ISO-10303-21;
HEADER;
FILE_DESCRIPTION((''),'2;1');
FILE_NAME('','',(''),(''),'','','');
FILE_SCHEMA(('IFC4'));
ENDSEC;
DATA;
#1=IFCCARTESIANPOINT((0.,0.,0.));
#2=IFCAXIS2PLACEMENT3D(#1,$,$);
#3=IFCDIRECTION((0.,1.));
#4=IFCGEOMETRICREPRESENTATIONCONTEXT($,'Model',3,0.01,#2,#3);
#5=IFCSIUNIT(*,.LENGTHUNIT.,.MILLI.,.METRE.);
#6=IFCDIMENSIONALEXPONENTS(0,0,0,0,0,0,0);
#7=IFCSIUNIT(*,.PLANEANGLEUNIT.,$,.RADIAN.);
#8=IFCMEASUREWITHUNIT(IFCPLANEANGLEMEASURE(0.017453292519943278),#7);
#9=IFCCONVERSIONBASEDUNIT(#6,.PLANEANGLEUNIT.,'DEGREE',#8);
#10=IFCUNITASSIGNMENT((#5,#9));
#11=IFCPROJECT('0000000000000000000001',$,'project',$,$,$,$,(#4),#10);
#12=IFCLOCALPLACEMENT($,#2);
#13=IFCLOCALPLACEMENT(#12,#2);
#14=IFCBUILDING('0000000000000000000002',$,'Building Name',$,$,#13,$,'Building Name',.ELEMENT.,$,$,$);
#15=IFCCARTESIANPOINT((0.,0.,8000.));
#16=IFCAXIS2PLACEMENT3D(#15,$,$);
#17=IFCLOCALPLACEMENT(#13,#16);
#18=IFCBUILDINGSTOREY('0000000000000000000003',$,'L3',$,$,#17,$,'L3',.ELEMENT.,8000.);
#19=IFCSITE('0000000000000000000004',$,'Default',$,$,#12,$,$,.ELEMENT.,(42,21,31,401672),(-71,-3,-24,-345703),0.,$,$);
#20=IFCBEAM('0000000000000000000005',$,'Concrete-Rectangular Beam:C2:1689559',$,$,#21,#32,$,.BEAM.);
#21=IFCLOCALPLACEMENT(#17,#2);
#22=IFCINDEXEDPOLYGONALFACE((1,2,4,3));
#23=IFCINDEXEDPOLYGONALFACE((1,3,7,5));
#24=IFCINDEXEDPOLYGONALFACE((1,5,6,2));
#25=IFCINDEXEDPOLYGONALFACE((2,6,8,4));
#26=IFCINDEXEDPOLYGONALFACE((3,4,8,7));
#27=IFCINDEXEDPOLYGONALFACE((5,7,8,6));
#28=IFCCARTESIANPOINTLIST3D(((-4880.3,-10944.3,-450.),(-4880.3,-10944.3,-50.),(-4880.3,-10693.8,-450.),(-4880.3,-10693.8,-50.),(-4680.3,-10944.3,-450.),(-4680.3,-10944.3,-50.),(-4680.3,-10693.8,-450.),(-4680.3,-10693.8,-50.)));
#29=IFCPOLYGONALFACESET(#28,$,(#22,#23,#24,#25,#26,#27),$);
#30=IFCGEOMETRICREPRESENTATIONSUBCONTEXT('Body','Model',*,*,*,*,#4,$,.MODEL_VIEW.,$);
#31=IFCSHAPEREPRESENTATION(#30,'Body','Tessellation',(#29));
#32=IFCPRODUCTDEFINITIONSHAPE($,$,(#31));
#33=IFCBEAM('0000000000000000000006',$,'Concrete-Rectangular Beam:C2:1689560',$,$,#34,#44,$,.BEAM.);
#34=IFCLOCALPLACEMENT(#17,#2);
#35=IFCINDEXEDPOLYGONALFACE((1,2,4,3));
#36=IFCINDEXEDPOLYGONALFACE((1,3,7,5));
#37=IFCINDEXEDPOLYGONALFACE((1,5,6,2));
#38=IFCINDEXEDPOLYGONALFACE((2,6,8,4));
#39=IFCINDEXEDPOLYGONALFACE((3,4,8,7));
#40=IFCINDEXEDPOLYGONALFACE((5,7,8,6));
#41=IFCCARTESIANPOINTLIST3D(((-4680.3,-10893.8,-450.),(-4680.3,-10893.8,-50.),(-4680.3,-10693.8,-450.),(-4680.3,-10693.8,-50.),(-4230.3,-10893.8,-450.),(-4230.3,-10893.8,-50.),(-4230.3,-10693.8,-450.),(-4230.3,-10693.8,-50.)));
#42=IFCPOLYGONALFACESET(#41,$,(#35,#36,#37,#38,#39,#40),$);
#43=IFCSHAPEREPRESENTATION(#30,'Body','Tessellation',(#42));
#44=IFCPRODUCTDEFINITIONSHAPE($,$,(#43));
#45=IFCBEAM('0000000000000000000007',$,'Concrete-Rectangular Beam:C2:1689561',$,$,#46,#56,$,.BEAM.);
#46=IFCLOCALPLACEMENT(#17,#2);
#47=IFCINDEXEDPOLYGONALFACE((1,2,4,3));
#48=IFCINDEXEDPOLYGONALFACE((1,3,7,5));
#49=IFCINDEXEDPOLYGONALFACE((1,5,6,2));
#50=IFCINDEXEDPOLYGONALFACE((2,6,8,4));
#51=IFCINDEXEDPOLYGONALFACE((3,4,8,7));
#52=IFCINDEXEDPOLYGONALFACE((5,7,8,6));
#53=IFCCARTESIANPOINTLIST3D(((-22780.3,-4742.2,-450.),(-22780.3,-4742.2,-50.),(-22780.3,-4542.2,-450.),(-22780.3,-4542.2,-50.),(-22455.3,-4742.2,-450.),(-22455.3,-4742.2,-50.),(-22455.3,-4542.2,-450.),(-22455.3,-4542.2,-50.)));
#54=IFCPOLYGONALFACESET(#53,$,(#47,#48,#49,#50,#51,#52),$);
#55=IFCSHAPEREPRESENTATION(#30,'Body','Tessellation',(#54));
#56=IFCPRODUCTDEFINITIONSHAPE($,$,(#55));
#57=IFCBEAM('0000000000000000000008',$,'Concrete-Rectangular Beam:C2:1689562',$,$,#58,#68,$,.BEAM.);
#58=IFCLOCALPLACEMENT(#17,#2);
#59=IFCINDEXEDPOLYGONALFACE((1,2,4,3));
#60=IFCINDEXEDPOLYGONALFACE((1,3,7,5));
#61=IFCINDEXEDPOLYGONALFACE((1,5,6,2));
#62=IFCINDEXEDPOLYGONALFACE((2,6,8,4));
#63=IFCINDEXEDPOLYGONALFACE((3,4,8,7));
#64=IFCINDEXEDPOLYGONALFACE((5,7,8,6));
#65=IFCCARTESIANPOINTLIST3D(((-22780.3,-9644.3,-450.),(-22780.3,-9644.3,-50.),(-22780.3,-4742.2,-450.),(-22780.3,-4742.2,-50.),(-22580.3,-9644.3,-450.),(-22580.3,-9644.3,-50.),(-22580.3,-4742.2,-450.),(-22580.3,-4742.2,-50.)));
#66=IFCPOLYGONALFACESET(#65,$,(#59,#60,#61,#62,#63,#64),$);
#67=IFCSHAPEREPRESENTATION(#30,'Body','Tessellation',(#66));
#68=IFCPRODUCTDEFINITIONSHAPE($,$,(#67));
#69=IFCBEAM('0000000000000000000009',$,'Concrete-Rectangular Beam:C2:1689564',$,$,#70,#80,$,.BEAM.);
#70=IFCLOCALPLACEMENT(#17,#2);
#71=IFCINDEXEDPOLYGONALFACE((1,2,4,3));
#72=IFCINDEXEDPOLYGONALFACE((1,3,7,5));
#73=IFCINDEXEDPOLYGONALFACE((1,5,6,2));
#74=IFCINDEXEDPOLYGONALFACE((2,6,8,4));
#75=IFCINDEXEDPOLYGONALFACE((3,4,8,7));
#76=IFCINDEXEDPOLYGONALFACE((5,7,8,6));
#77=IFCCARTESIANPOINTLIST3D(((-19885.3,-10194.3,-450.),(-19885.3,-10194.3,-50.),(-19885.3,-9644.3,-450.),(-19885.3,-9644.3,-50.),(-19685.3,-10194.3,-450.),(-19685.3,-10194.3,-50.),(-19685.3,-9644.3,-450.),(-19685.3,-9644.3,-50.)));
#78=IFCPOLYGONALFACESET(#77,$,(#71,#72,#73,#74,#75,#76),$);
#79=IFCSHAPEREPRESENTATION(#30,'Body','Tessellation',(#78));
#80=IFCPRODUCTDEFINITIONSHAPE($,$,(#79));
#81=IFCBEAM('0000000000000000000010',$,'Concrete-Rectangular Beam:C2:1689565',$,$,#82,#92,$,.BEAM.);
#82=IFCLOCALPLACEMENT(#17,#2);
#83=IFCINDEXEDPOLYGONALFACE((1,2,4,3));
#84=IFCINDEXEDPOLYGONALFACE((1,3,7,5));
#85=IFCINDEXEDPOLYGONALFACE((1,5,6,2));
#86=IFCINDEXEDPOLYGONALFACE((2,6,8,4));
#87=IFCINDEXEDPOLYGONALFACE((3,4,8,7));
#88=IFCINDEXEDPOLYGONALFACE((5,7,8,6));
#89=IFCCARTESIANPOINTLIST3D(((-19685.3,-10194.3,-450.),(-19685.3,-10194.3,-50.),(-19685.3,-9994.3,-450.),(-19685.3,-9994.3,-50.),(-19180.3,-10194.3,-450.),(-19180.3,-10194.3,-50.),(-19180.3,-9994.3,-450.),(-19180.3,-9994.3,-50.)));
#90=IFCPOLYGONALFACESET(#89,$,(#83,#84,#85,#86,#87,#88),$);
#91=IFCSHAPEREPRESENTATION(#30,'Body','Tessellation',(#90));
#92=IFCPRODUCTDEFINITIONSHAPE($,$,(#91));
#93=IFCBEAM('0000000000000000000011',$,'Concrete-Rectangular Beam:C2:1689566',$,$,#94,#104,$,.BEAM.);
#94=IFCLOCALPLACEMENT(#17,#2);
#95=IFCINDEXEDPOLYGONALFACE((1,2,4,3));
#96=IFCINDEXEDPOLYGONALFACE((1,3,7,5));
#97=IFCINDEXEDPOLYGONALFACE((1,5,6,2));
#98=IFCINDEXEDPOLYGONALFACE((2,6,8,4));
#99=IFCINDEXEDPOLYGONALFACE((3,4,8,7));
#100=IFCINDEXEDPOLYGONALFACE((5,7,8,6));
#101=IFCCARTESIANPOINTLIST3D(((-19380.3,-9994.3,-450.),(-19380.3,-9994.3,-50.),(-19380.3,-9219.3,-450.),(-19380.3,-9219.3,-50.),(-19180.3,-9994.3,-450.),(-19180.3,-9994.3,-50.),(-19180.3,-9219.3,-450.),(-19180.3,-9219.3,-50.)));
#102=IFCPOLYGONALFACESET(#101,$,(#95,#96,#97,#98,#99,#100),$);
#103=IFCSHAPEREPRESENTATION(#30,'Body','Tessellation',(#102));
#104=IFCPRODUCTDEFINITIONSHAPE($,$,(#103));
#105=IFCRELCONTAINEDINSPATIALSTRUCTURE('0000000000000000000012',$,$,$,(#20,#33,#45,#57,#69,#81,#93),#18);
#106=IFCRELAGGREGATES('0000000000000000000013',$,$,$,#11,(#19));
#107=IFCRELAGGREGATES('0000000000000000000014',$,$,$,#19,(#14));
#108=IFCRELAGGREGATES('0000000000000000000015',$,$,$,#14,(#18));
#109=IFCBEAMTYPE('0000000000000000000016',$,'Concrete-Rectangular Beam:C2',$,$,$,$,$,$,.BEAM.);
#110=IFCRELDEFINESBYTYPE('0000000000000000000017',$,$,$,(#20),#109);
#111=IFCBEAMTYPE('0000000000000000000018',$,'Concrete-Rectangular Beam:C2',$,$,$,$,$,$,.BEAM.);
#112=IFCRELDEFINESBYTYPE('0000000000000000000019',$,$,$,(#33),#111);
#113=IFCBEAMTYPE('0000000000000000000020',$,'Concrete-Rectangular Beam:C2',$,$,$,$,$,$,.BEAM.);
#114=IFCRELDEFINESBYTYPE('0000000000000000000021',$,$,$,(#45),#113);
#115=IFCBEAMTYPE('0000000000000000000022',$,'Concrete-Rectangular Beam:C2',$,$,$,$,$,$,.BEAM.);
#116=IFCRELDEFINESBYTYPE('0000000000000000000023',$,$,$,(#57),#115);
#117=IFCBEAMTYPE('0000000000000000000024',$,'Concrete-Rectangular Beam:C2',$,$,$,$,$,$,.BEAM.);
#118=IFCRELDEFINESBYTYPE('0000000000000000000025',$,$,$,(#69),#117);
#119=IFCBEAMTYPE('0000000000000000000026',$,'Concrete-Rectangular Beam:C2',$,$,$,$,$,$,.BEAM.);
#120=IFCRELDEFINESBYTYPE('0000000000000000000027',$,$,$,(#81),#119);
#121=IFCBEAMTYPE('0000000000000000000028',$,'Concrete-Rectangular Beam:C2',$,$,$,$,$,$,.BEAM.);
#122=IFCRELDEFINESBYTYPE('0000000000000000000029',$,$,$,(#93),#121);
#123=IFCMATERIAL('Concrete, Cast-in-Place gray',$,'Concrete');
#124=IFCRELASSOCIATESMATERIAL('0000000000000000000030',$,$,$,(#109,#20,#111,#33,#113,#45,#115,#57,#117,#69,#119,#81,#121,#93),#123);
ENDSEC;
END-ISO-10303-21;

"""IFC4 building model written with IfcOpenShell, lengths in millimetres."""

from ifc_helpers import new_model, entity, si_unit, converted_unit, direction, frame, origin, place, context, subcontext, project, spatial, indexed_curve, outline, extrude, source, transform, mapped, material, type_object, type_shapes, element, save


model = new_model("IFC4")

# Units and contexts
model_context = context("Model", 3, precision=0.01, world=origin(), true_north=direction((0.0, 1.0)))
body_context = subcontext(model_context, "Body", "Model", "MODEL_VIEW")
ifc_project = project(units=[si_unit("LENGTHUNIT", "METRE", prefix="MILLI"), converted_unit("PLANEANGLEUNIT", "DEGREE", entity("IfcPlaneAngleMeasure", 0.017453292519943278), si_unit("PLANEANGLEUNIT", "RADIAN"), dimensions=[0, 0, 0, 0, 0, 0, 0])], contexts=[model_context])

# Site, building, storey
site_placement = place(None, origin())
site = spatial("IfcSite", under=ifc_project, at=site_placement, Name="Default", CompositionType="ELEMENT", RefLatitude=(42, 21, 31, 401672), RefLongitude=(-71, -3, -24, -345703), RefElevation=0.0)
building_placement = place(site_placement, origin())
building = spatial("IfcBuilding", under=site, at=building_placement, Name="Building Name", LongName="Building Name", CompositionType="ELEMENT")
storey_placement = place(building_placement, frame((0.0, 0.0, 8000.0)))
storey = spatial("IfcBuildingStorey", under=building, at=storey_placement, Name="L3", LongName="L3", CompositionType="ELEMENT", Elevation=8000.0)

# Beams
ifc_material = material(Name="Concrete, Cast-in-Place gray", Category="Concrete")
beam_type_1 = type_object("IfcBeamType", Name="Concrete-Rectangular Beam:C2", PredefinedType="BEAM", material=ifc_material)
shared_shape_1 = source(origin(), body_context, "Body", "SweptSolid", [
    extrude(outline(indexed_curve([(-100.0, -200.0), (100.0, -200.0), (100.0, 200.0), (-100.0, 200.0), (-100.0, -200.0)], self_intersect=False)), frame((-4780.3, -10944.3, 7750.0), z_axis=(0.0, 1.0, 0.0), x_axis=(-1.0, 0.0, 0.0)), (0.0, 0.0, 1.0), 250.5),
])
type_shapes(beam_type_1, [shared_shape_1])
beam_1_placement = place(storey_placement, frame((0.0, 0.0, -8000.0)))
element("IfcBeam", 1, at=beam_1_placement, inside=storey, type_object=beam_type_1, material=ifc_material, Name="Concrete-Rectangular Beam:C2:1689559", PredefinedType="BEAM", context=body_context, shape_type="MappedRepresentation", body=[
    mapped(shared_shape_1, transform((0.0, 0.0, 0.0), scale=1.0)),
])
beam_type_2 = type_object("IfcBeamType", Name="Concrete-Rectangular Beam:C2", PredefinedType="BEAM", material=ifc_material)
shared_shape_2 = source(origin(), body_context, "Body", "SweptSolid", [
    extrude(outline(indexed_curve([(-200.0, -100.0), (200.0, -100.0), (200.0, 100.0), (-200.0, 100.0), (-200.0, -100.0)], self_intersect=False)), frame((-4680.3, -10793.8, 7750.0), z_axis=(1.0, 0.0, 0.0), x_axis=(0.0, 0.0, -1.0)), (0.0, 0.0, 1.0), 450.0),
])
type_shapes(beam_type_2, [shared_shape_2])
beam_2_placement = place(storey_placement, frame((0.0, 0.0, -8000.0)))
element("IfcBeam", 2, at=beam_2_placement, inside=storey, type_object=beam_type_2, material=ifc_material, Name="Concrete-Rectangular Beam:C2:1689560", PredefinedType="BEAM", context=body_context, shape_type="MappedRepresentation", body=[
    mapped(shared_shape_2, transform((0.0, 0.0, 0.0), scale=1.0)),
])
beam_type_3 = type_object("IfcBeamType", Name="Concrete-Rectangular Beam:C2", PredefinedType="BEAM", material=ifc_material)
shared_shape_3 = source(origin(), body_context, "Body", "SweptSolid", [
    extrude(outline(indexed_curve([(-200.0, -100.0), (200.0, -100.0), (200.0, 100.0), (-200.0, 100.0), (-200.0, -100.0)], self_intersect=False)), frame((-22455.3, -4642.2, 7750.0), z_axis=(-1.0, 0.0, 0.0), x_axis=(0.0, 0.0, -1.0)), (0.0, 0.0, 1.0), 325.0),
])
type_shapes(beam_type_3, [shared_shape_3])
beam_3_placement = place(storey_placement, frame((0.0, 0.0, -8000.0)))
element("IfcBeam", 3, at=beam_3_placement, inside=storey, type_object=beam_type_3, material=ifc_material, Name="Concrete-Rectangular Beam:C2:1689561", PredefinedType="BEAM", context=body_context, shape_type="MappedRepresentation", body=[
    mapped(shared_shape_3, transform((0.0, 0.0, 0.0), scale=1.0)),
])
beam_type_4 = type_object("IfcBeamType", Name="Concrete-Rectangular Beam:C2", PredefinedType="BEAM", material=ifc_material)
shared_shape_4 = source(origin(), body_context, "Body", "SweptSolid", [
    extrude(outline(indexed_curve([(-100.0, -200.0), (100.0, -200.0), (100.0, 200.0), (-100.0, 200.0), (-100.0, -200.0)], self_intersect=False)), frame((-22680.3, -4742.2, 7750.0), z_axis=(0.0, -1.0, 0.0), x_axis=(-1.0, 0.0, 0.0)), (0.0, 0.0, 1.0), 4902.1),
])
type_shapes(beam_type_4, [shared_shape_4])
beam_4_placement = place(storey_placement, frame((0.0, 0.0, -8000.0)))
element("IfcBeam", 4, at=beam_4_placement, inside=storey, type_object=beam_type_4, material=ifc_material, Name="Concrete-Rectangular Beam:C2:1689562", PredefinedType="BEAM", context=body_context, shape_type="MappedRepresentation", body=[
    mapped(shared_shape_4, transform((0.0, 0.0, 0.0), scale=1.0)),
])
beam_type_5 = type_object("IfcBeamType", Name="Concrete-Rectangular Beam:C2", PredefinedType="BEAM", material=ifc_material)
shared_shape_5 = source(origin(), body_context, "Body", "SweptSolid", [
    extrude(outline(indexed_curve([(-100.0, -200.0), (100.0, -200.0), (100.0, 200.0), (-100.0, 200.0), (-100.0, -200.0)], self_intersect=False)), frame((-19785.3, -9644.3, 7750.0), z_axis=(0.0, -1.0, 0.0), x_axis=(-1.0, 0.0, 0.0)), (0.0, 0.0, 1.0), 550.0),
])
type_shapes(beam_type_5, [shared_shape_5])
beam_5_placement = place(storey_placement, frame((0.0, 0.0, -8000.0)))
element("IfcBeam", 5, at=beam_5_placement, inside=storey, type_object=beam_type_5, material=ifc_material, Name="Concrete-Rectangular Beam:C2:1689564", PredefinedType="BEAM", context=body_context, shape_type="MappedRepresentation", body=[
    mapped(shared_shape_5, transform((0.0, 0.0, 0.0), scale=1.0)),
])
beam_type_6 = type_object("IfcBeamType", Name="Concrete-Rectangular Beam:C2", PredefinedType="BEAM", material=ifc_material)
shared_shape_6 = source(origin(), body_context, "Body", "SweptSolid", [
    extrude(outline(indexed_curve([(-200.0, -100.0), (200.0, -100.0), (200.0, 100.0), (-200.0, 100.0), (-200.0, -100.0)], self_intersect=False)), frame((-19685.3, -10094.3, 7750.0), z_axis=(1.0, 0.0, 0.0), x_axis=(0.0, 0.0, -1.0)), (0.0, 0.0, 1.0), 505.0),
])
type_shapes(beam_type_6, [shared_shape_6])
beam_6_placement = place(storey_placement, frame((0.0, 0.0, -8000.0)))
element("IfcBeam", 6, at=beam_6_placement, inside=storey, type_object=beam_type_6, material=ifc_material, Name="Concrete-Rectangular Beam:C2:1689565", PredefinedType="BEAM", context=body_context, shape_type="MappedRepresentation", body=[
    mapped(shared_shape_6, transform((0.0, 0.0, 0.0), scale=1.0)),
])
beam_type_7 = type_object("IfcBeamType", Name="Concrete-Rectangular Beam:C2", PredefinedType="BEAM", material=ifc_material)
shared_shape_7 = source(origin(), body_context, "Body", "SweptSolid", [
    extrude(outline(indexed_curve([(-100.0, -200.0), (100.0, -200.0), (100.0, 200.0), (-100.0, 200.0), (-100.0, -200.0)], self_intersect=False)), frame((-19280.3, -9994.3, 7750.0), z_axis=(0.0, 1.0, 0.0), x_axis=(-1.0, 0.0, 0.0)), (0.0, 0.0, 1.0), 775.0),
])
type_shapes(beam_type_7, [shared_shape_7])
beam_7_placement = place(storey_placement, frame((0.0, 0.0, -8000.0)))
element("IfcBeam", 7, at=beam_7_placement, inside=storey, type_object=beam_type_7, material=ifc_material, Name="Concrete-Rectangular Beam:C2:1689566", PredefinedType="BEAM", context=body_context, shape_type="MappedRepresentation", body=[
    mapped(shared_shape_7, transform((0.0, 0.0, 0.0), scale=1.0)),
])

save(model, "model.ifc")
